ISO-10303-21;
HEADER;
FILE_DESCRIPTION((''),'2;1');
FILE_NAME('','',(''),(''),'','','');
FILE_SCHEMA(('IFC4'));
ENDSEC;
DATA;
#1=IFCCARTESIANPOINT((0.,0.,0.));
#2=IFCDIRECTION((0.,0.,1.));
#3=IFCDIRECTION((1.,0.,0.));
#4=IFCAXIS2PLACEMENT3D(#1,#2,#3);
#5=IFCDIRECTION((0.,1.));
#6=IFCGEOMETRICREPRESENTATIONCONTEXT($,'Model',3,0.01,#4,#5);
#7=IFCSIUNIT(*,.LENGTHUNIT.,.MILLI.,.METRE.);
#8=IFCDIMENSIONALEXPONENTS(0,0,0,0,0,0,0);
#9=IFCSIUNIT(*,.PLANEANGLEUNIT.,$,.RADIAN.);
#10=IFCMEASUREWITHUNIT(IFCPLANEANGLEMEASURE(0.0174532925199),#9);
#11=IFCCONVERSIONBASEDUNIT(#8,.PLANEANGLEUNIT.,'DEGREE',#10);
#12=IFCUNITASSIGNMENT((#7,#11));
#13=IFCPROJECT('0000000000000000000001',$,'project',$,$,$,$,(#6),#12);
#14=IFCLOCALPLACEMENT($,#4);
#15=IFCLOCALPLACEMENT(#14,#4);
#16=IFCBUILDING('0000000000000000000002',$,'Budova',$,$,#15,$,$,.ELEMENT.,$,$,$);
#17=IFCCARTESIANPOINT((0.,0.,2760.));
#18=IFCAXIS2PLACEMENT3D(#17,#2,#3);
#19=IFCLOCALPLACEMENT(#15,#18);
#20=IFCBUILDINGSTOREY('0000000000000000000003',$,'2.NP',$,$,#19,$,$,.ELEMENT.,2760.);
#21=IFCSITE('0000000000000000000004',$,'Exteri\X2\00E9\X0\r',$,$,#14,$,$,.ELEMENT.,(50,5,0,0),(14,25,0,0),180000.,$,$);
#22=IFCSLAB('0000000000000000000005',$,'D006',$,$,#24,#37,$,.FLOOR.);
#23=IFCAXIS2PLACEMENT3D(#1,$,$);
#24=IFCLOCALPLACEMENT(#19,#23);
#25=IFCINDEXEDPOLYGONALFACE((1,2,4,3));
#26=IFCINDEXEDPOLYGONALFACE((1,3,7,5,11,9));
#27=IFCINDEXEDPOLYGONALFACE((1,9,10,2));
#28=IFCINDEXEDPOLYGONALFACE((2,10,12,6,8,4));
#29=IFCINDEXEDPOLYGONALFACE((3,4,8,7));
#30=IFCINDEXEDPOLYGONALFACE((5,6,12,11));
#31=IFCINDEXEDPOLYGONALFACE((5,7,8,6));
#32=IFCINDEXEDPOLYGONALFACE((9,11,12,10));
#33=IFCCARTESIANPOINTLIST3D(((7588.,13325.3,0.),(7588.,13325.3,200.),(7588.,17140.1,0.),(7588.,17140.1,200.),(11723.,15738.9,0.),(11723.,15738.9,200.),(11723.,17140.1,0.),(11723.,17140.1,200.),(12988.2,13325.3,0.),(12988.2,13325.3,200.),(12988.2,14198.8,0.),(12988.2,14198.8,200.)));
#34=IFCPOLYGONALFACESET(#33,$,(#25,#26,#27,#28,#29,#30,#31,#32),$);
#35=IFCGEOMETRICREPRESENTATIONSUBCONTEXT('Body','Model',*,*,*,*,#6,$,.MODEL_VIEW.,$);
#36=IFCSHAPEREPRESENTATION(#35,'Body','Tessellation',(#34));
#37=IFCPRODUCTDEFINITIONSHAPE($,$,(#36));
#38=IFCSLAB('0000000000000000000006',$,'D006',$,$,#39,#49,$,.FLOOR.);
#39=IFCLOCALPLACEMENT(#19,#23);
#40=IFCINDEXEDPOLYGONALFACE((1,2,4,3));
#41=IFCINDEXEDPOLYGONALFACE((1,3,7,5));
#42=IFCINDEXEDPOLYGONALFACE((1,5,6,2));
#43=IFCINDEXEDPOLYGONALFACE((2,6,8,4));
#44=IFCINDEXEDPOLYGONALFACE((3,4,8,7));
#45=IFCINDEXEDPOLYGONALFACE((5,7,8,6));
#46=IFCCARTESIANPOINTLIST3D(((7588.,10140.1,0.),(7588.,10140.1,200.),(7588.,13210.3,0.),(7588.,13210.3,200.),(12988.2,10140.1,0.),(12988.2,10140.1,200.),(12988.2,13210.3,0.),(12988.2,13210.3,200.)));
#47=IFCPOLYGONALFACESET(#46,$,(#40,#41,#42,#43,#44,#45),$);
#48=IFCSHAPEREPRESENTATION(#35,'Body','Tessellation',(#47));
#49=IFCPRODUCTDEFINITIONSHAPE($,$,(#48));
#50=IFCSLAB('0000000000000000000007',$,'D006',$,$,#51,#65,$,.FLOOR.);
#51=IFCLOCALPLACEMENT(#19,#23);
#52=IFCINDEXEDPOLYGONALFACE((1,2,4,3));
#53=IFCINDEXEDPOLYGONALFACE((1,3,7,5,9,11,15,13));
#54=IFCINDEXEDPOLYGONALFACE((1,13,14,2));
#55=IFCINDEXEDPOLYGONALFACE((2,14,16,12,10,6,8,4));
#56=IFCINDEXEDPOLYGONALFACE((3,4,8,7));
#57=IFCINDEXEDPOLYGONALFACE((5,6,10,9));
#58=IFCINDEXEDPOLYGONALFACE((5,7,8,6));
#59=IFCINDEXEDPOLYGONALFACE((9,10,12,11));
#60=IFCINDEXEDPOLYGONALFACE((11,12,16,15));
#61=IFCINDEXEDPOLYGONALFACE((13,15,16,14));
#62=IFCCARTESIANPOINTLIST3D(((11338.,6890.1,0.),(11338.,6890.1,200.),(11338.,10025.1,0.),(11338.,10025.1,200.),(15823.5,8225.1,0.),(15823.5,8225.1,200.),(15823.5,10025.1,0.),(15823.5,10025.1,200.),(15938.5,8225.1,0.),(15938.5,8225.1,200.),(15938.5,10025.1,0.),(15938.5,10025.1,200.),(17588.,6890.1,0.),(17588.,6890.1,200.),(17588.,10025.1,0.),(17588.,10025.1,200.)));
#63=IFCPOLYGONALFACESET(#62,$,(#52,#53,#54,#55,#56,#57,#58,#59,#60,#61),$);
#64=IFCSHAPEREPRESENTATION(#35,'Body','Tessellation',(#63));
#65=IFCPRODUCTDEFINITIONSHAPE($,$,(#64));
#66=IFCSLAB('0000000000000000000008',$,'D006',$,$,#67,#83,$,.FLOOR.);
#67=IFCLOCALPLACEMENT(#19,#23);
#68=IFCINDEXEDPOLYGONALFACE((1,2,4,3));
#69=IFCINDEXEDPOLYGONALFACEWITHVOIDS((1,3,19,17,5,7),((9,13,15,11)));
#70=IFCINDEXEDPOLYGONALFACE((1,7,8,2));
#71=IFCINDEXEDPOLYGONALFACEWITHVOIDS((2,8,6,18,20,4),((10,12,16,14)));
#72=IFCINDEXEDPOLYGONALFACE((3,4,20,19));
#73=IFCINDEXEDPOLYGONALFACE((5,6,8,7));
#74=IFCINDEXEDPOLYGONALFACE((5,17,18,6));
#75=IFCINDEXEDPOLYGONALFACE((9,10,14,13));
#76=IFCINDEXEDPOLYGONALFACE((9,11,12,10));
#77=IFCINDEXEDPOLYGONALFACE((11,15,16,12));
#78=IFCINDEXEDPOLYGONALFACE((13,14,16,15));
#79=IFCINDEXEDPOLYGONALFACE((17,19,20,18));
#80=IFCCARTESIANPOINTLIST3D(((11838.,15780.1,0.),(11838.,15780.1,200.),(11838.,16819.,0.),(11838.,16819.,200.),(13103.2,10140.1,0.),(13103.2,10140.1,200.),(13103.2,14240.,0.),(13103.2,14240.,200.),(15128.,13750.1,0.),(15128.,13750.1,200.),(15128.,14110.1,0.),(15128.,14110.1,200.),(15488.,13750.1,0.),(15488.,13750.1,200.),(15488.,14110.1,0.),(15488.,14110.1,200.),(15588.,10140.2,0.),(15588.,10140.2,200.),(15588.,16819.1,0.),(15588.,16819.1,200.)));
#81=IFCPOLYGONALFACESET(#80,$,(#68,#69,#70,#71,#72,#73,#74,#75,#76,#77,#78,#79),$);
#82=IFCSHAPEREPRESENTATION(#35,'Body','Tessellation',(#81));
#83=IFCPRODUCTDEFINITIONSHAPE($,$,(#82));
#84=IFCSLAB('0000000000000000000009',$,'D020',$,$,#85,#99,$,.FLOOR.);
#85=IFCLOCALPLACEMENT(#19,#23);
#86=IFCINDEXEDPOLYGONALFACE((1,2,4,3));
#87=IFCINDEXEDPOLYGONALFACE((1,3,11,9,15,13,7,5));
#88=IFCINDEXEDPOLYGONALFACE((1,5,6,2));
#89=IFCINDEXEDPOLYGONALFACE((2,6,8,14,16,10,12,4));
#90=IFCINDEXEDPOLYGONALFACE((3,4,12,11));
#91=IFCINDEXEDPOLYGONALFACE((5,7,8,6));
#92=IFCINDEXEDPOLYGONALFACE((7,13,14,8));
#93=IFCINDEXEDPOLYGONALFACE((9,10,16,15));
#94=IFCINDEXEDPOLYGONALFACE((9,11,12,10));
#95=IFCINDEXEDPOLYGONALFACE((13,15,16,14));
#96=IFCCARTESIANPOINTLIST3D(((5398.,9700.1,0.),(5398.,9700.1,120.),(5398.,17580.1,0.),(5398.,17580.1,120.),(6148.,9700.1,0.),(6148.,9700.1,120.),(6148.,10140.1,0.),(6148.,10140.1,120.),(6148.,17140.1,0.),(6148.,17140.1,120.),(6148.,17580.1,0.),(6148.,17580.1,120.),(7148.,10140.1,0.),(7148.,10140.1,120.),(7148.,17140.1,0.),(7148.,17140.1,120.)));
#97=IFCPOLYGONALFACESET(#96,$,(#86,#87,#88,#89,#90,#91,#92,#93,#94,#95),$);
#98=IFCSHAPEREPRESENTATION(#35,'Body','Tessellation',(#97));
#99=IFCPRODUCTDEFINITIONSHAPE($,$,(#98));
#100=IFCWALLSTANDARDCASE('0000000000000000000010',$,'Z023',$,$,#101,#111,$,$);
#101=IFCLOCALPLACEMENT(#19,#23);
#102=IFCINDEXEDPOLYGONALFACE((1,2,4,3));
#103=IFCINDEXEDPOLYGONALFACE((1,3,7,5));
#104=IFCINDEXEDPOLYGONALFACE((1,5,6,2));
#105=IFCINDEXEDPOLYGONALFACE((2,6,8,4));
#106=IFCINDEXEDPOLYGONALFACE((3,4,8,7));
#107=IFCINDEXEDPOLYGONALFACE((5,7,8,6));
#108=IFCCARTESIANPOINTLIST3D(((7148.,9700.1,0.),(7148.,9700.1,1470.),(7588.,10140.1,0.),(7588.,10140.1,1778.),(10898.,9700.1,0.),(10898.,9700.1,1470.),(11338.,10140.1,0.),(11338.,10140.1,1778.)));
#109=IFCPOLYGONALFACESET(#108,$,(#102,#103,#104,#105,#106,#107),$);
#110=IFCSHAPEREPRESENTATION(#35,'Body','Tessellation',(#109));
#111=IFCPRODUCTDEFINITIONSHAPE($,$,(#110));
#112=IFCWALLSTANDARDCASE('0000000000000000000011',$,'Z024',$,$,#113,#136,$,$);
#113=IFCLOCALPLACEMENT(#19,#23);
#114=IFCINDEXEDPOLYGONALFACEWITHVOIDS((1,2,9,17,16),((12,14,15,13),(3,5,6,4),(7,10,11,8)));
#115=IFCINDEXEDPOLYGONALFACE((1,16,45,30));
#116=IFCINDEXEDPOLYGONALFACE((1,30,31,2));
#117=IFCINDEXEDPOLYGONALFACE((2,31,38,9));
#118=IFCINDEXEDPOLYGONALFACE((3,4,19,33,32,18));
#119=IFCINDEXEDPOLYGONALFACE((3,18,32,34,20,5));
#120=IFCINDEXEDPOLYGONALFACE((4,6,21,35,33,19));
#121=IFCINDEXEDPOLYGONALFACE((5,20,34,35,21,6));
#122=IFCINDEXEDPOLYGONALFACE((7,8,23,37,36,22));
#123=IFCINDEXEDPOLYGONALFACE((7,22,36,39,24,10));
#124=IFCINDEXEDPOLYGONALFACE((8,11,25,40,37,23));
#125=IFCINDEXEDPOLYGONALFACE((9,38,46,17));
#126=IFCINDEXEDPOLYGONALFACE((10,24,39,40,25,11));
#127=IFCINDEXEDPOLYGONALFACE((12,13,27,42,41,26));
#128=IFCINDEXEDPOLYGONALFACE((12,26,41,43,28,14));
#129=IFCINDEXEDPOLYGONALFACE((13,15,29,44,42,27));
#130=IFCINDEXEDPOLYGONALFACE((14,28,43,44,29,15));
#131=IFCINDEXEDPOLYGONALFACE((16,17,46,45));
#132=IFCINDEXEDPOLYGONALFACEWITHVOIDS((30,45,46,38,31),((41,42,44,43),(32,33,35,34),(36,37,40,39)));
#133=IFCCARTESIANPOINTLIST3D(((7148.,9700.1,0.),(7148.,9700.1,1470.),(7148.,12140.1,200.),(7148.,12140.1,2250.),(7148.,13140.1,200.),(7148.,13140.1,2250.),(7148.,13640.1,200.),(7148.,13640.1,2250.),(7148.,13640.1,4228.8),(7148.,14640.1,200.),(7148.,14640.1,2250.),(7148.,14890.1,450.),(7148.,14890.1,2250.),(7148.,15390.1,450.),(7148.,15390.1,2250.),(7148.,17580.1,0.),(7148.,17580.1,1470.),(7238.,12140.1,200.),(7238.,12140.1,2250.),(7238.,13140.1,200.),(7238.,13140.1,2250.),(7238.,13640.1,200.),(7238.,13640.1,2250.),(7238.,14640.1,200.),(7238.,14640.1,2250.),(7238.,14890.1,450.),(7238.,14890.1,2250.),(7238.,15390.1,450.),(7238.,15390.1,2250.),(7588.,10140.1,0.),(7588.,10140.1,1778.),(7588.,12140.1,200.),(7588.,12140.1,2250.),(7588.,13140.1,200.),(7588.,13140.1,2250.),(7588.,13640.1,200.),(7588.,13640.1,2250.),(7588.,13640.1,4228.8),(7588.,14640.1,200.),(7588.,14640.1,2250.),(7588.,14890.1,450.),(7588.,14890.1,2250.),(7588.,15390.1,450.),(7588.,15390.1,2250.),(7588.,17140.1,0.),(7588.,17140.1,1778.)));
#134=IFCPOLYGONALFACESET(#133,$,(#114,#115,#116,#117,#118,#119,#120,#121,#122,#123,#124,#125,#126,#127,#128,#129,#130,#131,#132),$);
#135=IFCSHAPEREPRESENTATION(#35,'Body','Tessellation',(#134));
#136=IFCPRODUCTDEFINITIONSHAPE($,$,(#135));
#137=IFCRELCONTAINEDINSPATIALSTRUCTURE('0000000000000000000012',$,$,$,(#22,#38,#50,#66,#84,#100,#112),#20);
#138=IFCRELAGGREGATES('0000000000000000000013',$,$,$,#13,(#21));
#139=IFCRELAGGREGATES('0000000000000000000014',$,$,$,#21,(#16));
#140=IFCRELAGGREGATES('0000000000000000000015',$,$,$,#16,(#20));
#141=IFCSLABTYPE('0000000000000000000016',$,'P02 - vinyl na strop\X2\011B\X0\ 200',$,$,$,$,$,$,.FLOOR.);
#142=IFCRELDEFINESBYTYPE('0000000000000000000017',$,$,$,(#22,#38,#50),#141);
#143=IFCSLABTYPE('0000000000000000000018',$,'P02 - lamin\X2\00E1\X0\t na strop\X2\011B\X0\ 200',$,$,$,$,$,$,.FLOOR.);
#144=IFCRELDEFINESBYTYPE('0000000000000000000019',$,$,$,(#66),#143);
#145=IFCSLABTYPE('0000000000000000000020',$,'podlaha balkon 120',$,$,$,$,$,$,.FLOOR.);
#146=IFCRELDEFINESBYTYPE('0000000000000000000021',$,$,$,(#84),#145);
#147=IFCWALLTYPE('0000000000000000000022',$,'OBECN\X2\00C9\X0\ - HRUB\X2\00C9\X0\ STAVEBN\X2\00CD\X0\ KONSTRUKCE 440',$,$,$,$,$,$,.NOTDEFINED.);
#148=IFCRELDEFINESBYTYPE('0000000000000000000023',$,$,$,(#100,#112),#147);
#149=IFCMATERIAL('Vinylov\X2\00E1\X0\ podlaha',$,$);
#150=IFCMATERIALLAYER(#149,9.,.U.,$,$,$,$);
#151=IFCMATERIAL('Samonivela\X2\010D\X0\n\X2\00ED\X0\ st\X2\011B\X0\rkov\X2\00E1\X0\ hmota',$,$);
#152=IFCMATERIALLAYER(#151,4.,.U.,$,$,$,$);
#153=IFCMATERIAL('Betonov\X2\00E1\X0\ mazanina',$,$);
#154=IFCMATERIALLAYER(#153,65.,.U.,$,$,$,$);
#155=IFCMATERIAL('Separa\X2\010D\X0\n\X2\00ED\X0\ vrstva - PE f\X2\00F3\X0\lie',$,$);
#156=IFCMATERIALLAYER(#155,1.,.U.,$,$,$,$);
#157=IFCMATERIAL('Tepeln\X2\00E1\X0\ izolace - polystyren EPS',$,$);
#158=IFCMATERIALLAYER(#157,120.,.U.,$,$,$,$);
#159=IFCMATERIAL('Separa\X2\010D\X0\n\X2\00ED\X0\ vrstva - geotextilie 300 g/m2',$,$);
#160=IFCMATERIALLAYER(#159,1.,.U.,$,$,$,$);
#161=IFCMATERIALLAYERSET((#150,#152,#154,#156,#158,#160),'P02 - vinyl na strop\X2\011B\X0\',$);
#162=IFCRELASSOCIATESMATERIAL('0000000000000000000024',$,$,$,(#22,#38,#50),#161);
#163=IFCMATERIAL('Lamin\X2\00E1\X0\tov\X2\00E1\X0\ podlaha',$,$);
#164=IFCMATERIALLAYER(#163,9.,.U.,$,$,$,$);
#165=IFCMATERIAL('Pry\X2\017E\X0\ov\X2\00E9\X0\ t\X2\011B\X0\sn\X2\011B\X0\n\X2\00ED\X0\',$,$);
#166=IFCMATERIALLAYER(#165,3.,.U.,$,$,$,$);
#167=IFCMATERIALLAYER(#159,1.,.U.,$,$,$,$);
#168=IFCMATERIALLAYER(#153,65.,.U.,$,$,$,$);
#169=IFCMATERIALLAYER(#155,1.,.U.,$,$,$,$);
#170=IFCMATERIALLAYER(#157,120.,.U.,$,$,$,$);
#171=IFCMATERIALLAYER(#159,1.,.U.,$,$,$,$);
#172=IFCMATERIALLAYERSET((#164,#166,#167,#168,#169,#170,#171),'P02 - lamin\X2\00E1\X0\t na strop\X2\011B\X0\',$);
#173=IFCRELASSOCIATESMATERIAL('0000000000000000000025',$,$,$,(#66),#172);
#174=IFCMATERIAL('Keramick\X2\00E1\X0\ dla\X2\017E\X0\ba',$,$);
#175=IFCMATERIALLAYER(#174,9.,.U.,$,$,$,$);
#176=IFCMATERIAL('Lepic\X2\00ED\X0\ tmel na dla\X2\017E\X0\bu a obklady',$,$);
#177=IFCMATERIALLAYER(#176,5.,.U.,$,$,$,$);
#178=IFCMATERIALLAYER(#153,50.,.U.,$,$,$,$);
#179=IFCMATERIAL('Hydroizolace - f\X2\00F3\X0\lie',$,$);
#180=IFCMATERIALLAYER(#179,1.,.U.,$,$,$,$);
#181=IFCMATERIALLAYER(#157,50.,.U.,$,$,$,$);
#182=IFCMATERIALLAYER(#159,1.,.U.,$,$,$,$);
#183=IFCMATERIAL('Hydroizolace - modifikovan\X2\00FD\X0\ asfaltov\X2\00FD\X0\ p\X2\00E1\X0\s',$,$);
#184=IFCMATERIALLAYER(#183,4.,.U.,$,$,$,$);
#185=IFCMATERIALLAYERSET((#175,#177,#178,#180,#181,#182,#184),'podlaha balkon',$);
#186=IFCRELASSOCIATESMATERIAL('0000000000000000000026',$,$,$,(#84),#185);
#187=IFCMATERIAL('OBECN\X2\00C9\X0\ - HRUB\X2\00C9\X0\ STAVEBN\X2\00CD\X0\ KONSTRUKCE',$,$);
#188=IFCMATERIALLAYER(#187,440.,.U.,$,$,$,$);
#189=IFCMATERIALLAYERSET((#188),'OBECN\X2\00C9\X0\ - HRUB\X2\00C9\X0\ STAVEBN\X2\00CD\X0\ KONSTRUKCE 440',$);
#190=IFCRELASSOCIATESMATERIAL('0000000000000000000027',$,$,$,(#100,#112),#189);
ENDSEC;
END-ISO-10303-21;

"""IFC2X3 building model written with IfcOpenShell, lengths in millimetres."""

from ifc_helpers import new_model, entity, si_unit, converted_unit, direction, frame, origin_with_axes, origin_2d_with_axis, place, context, subcontext, project, spatial, polyline, rectangle, outline, extrude, clip, halfspace, bounded_halfspace, material, layer, layer_set, layer_usage, type_object, element, save


model = new_model("IFC2X3")

# Units and contexts
model_context = context("Model", 3, precision=0.01, world=origin_with_axes(), true_north=direction((0.0, 1.0)))
body_context = subcontext(model_context, "Body", "Model", "MODEL_VIEW")
ifc_project = project(units=[si_unit("LENGTHUNIT", "METRE", prefix="MILLI"), converted_unit("PLANEANGLEUNIT", "DEGREE", entity("IfcPlaneAngleMeasure", 0.0174532925199), si_unit("PLANEANGLEUNIT", "RADIAN"), dimensions=[0, 0, 0, 0, 0, 0, 0])], contexts=[model_context])

# Site, building, storey
site_placement = place(None, origin_with_axes())
site = spatial("IfcSite", under=ifc_project, at=site_placement, Name="Exteriér", CompositionType="ELEMENT", RefLatitude=(50, 5, 0, 0), RefLongitude=(14, 25, 0, 0), RefElevation=180000.0)
building_placement = place(site_placement, origin_with_axes())
building = spatial("IfcBuilding", under=site, at=building_placement, Name="Budova", CompositionType="ELEMENT")
storey_placement = place(building_placement, frame((0.0, 0.0, 2760.0), z_axis=(0.0, 0.0, 1.0), x_axis=(1.0, 0.0, 0.0)))
storey = spatial("IfcBuildingStorey", under=building, at=storey_placement, Name="2.NP", CompositionType="ELEMENT", Elevation=2760.0)

# Slabs
ifc_material_1 = material(Name="Vinylová podlaha")
ifc_layer_1 = layer(ifc_material_1, 9.0, ventilated="UNKNOWN")
ifc_material_2 = material(Name="Samonivelační stěrková hmota")
ifc_layer_2 = layer(ifc_material_2, 4.0, ventilated="UNKNOWN")
ifc_material_3 = material(Name="Betonová mazanina")
ifc_layer_3 = layer(ifc_material_3, 65.0, ventilated="UNKNOWN")
ifc_material_4 = material(Name="Separační vrstva - PE fólie")
ifc_layer_4 = layer(ifc_material_4, 1.0, ventilated="UNKNOWN")
ifc_material_5 = material(Name="Tepelná izolace - polystyren EPS")
ifc_layer_5 = layer(ifc_material_5, 120.0, ventilated="UNKNOWN")
ifc_material_6 = material(Name="Separační vrstva - geotextilie 300 g/m2")
ifc_layer_6 = layer(ifc_material_6, 1.0, ventilated="UNKNOWN")
ifc_layer_set_1 = layer_set([ifc_layer_1, ifc_layer_2, ifc_layer_3, ifc_layer_4, ifc_layer_5, ifc_layer_6], Name="P02 - vinyl na stropě")
ifc_layer_usage_1 = layer_usage(ifc_layer_set_1, "AXIS3", "NEGATIVE", 200.0)
slab_type_1 = type_object("IfcSlabType", Name="P02 - vinyl na stropě 200", PredefinedType="FLOOR")
slab_1_placement = place(storey_placement, frame((11723.0, 17140.1, 0.0), z_axis=(0.0, 0.0, 1.0), x_axis=(1.0, 0.0, 0.0)))
element("IfcSlab", 1, at=slab_1_placement, inside=storey, type_object=slab_type_1, material=ifc_layer_usage_1, Name="D006", PredefinedType="FLOOR", context=body_context, shape_type="SweptSolid", body=[
    extrude(outline(polyline([(0.0, 0.0), (-4135.0, 0.0), (-4135.0, -3814.9), (1265.2, -3814.9), (1265.2, -2941.3), (0.0, -1401.2), (0.0, 0.0)])), origin_with_axes(), (0.0, 0.0, 1.0), 200.0),
])
ifc_layer_usage_2 = layer_usage(ifc_layer_set_1, "AXIS3", "NEGATIVE", 200.0)
slab_2_placement = place(storey_placement, frame((7588.0, 13210.3, 0.0), z_axis=(0.0, 0.0, 1.0), x_axis=(1.0, 0.0, 0.0)))
element("IfcSlab", 2, at=slab_2_placement, inside=storey, type_object=slab_type_1, material=ifc_layer_usage_2, Name="D006", PredefinedType="FLOOR", context=body_context, shape_type="SweptSolid", body=[
    extrude(outline(polyline([(0.0, 0.0), (0.0, -3070.1), (5400.2, -3070.1), (5400.2, 0.0), (0.0, 0.0)])), origin_with_axes(), (0.0, 0.0, 1.0), 200.0),
])
ifc_layer_usage_3 = layer_usage(ifc_layer_set_1, "AXIS3", "NEGATIVE", 200.0)
slab_3_placement = place(storey_placement, frame((11338.0, 10025.1, 0.0), z_axis=(0.0, 0.0, 1.0), x_axis=(1.0, 0.0, 0.0)))
element("IfcSlab", 3, at=slab_3_placement, inside=storey, type_object=slab_type_1, material=ifc_layer_usage_3, Name="D006", PredefinedType="FLOOR", context=body_context, shape_type="SweptSolid", body=[
    extrude(outline(polyline([(0.0, 0.0), (0.0, -3135.0), (6250.0, -3135.0), (6250.0, 0.0), (4600.5, 0.0), (4600.5, -1800.0), (4485.5, -1800.0), (4485.5, 0.0), (0.0, 0.0)])), origin_with_axes(), (0.0, 0.0, 1.0), 200.0),
])

# Shared definitions
ifc_material_7 = material(Name="Hydroizolace - modifikovaný asfaltový pás")

# Slabs
ifc_material_8 = material(Name="Laminátová podlaha")
ifc_layer_7 = layer(ifc_material_8, 9.0, ventilated="UNKNOWN")
ifc_material_9 = material(Name="Pryžové těsnění")
ifc_layer_8 = layer(ifc_material_9, 3.0, ventilated="UNKNOWN")
ifc_layer_9 = layer(ifc_material_6, 1.0, ventilated="UNKNOWN")
ifc_layer_10 = layer(ifc_material_3, 65.0, ventilated="UNKNOWN")
ifc_layer_11 = layer(ifc_material_4, 1.0, ventilated="UNKNOWN")
ifc_layer_12 = layer(ifc_material_5, 120.0, ventilated="UNKNOWN")
ifc_layer_13 = layer(ifc_material_6, 1.0, ventilated="UNKNOWN")
ifc_layer_set_2 = layer_set([ifc_layer_7, ifc_layer_8, ifc_layer_9, ifc_layer_10, ifc_layer_11, ifc_layer_12, ifc_layer_13], Name="P02 - laminát na stropě")
ifc_layer_usage_4 = layer_usage(ifc_layer_set_2, "AXIS3", "NEGATIVE", 200.0)
slab_type_2 = type_object("IfcSlabType", Name="P02 - laminát na stropě 200", PredefinedType="FLOOR")
slab_4_placement = place(storey_placement, frame((11838.0, 16819.0, 0.0), z_axis=(0.0, 0.0, 1.0), x_axis=(1.0, 0.0, 0.0)))
element("IfcSlab", 4, at=slab_4_placement, inside=storey, type_object=slab_type_2, material=ifc_layer_usage_4, Name="D006", PredefinedType="FLOOR", context=body_context, shape_type="SweptSolid", body=[
    extrude(outline(polyline([(0.0, 0.0), (0.0, -1038.9), (1265.2, -2579.0), (1265.2, -6678.9), (3750.0, -6678.9), (3750.0, 0.1), (0.0, 0.0)]), holes=[polyline([(3650.0, -2708.9), (3650.0, -3068.9), (3290.0, -3068.9), (3290.0, -2708.9), (3650.0, -2708.9)])]), origin_with_axes(), (0.0, 0.0, 1.0), 200.0),
])
ifc_material_10 = material(Name="Keramická dlažba")
ifc_layer_14 = layer(ifc_material_10, 9.0, ventilated="UNKNOWN")
ifc_material_11 = material(Name="Lepicí tmel na dlažbu a obklady")
ifc_layer_15 = layer(ifc_material_11, 5.0, ventilated="UNKNOWN")
ifc_layer_16 = layer(ifc_material_3, 50.0, ventilated="UNKNOWN")
ifc_material_12 = material(Name="Hydroizolace - fólie")
ifc_layer_17 = layer(ifc_material_12, 1.0, ventilated="UNKNOWN")
ifc_layer_18 = layer(ifc_material_5, 50.0, ventilated="UNKNOWN")
ifc_layer_19 = layer(ifc_material_6, 1.0, ventilated="UNKNOWN")
ifc_layer_20 = layer(ifc_material_7, 4.0, ventilated="UNKNOWN")
ifc_layer_set_3 = layer_set([ifc_layer_14, ifc_layer_15, ifc_layer_16, ifc_layer_17, ifc_layer_18, ifc_layer_19, ifc_layer_20], Name="podlaha balkon")
ifc_layer_usage_5 = layer_usage(ifc_layer_set_3, "AXIS3", "NEGATIVE", 120.0)
slab_type_3 = type_object("IfcSlabType", Name="podlaha balkon 120", PredefinedType="FLOOR")
slab_5_placement = place(storey_placement, frame((5398.0, 17580.1, 0.0), z_axis=(0.0, 0.0, 1.0), x_axis=(1.0, 0.0, 0.0)))
element("IfcSlab", 5, at=slab_5_placement, inside=storey, type_object=slab_type_3, material=ifc_layer_usage_5, Name="D020", PredefinedType="FLOOR", context=body_context, shape_type="SweptSolid", body=[
    extrude(outline(polyline([(0.0, 0.0), (0.0, -7880.0), (750.0, -7880.0), (750.0, -7440.0), (1750.0, -7440.0), (1750.0, -440.0), (750.0, -440.0), (750.0, 0.0), (0.0, 0.0)])), origin_with_axes(), (0.0, 0.0, 1.0), 120.0),
])

# Wall
ifc_material_13 = material(Name="OBECNÉ - HRUBÉ STAVEBNÍ KONSTRUKCE")
ifc_layer_21 = layer(ifc_material_13, 440.0, ventilated="UNKNOWN")
ifc_layer_set_4 = layer_set([ifc_layer_21], Name="OBECNÉ - HRUBÉ STAVEBNÍ KONSTRUKCE 440")
ifc_layer_usage_6 = layer_usage(ifc_layer_set_4, "AXIS2", "POSITIVE", -440.0)
wall_type_1 = type_object("IfcWallType", Name="OBECNÉ - HRUBÉ STAVEBNÍ KONSTRUKCE 440", PredefinedType="NOTDEFINED")
wall_1_placement = place(storey_placement, frame((10898.0, 9700.1, 0.0), z_axis=(0.0, 0.0, 1.0), x_axis=(-1.0, 0.0, 0.0)))
element("IfcWallStandardCase", 6, at=wall_1_placement, inside=storey, type_object=wall_type_1, material=ifc_layer_usage_6, Name="Z023", context=body_context, shape_type="Clipping", body=[
    clip(extrude(outline(polyline([(-440.0, -440.0), (3310.0, -440.0), (3750.0, 0.0), (0.0, 0.0), (-440.0, -440.0)])), origin_with_axes(), (0.0, 0.0, 1.0), 2000.0), halfspace(frame((0.0, 690.7, 986.4), z_axis=(0.0, -0.573576, -0.819152), x_axis=(0.0, 0.819152, -0.573576)), True)),
])

# Wall, openings
ifc_layer_usage_7 = layer_usage(ifc_layer_set_4, "AXIS2", "POSITIVE", -440.0)
wall_2_placement = place(storey_placement, frame((7148.0, 9700.1, 0.0), z_axis=(0.0, 0.0, 1.0), x_axis=(0.0, 1.0, 0.0)))
wall_2 = element("IfcWallStandardCase", 7, at=wall_2_placement, inside=storey, type_object=wall_type_1, material=ifc_layer_usage_7, Name="Z024", context=body_context, shape_type="Clipping", body=[
    clip(clip(extrude(outline(polyline([(440.0, -440.0), (7440.0, -440.0), (7880.0, 0.0), (0.0, 0.0), (440.0, -440.0)])), origin_with_axes(), (0.0, 0.0, 1.0), 6000.0), bounded_halfspace(frame((3283.1, 0.0, 4688.7), z_axis=(-0.573576, 0.0, -0.819152), x_axis=(0.0, 1.0, 0.0)), True, origin_with_axes(), polyline([(3940.0, -450.0), (8280.0, -450.0), (8280.0, 10.0), (3940.0, 10.0), (3940.0, -450.0)]))), bounded_halfspace(frame((-690.7, 0.0, 986.4), z_axis=(0.573576, 0.0, -0.819152), x_axis=(0.0, 1.0, 0.0)), True, origin_with_axes(), polyline([(-436.0, -450.0), (3940.0, -450.0), (3940.0, 10.0), (-436.0, 10.0), (-436.0, -450.0)]))),
])
opening_1_placement = place(wall_2_placement, frame((4440.0, 0.0, 200.0), z_axis=(0.0, 0.0, 1.0), x_axis=(1.0, 0.0, 0.0)))
element("IfcOpeningElement", 8, at=opening_1_placement, cuts=wall_2, context=body_context, shape_type="SweptSolid", body=[
    extrude(rectangle(XDim=1000.0, YDim=2050.0, at=origin_2d_with_axis()), frame((0.0, -90.0, 1025.0), z_axis=(0.0, 1.0, 0.0), x_axis=(-1.0, 0.0, 0.0)), (0.0, 0.0, -1.0), 790.0),
    extrude(rectangle(XDim=1000.0, YDim=2050.0, at=origin_2d_with_axis()), frame((0.0, -90.0, 1025.0), z_axis=(0.0, -1.0, 0.0), x_axis=(-1.0, 0.0, 0.0)), (0.0, 0.0, -1.0), 530.0),
])
opening_2_placement = place(wall_2_placement, frame((2940.0, 0.0, 200.0), z_axis=(0.0, 0.0, 1.0), x_axis=(1.0, 0.0, 0.0)))
element("IfcOpeningElement", 9, at=opening_2_placement, cuts=wall_2, context=body_context, shape_type="SweptSolid", body=[
    extrude(rectangle(XDim=1000.0, YDim=2050.0, at=origin_2d_with_axis()), frame((0.0, -90.0, 1025.0), z_axis=(0.0, -1.0, 0.0), x_axis=(1.0, 0.0, 0.0)), (0.0, 0.0, 1.0), 790.0),
    extrude(rectangle(XDim=1000.0, YDim=2050.0, at=origin_2d_with_axis()), frame((0.0, -90.0, 1025.0), z_axis=(0.0, 1.0, 0.0), x_axis=(1.0, 0.0, 0.0)), (0.0, 0.0, 1.0), 530.0),
])
opening_3_placement = place(wall_2_placement, frame((5440.0, 0.0, 450.0), z_axis=(0.0, 0.0, 1.0), x_axis=(1.0, 0.0, 0.0)))
element("IfcOpeningElement", 10, at=opening_3_placement, cuts=wall_2, context=body_context, shape_type="SweptSolid", body=[
    extrude(rectangle(XDim=500.0, YDim=1800.0, at=origin_2d_with_axis()), frame((0.0, -90.0, 900.0), z_axis=(0.0, 1.0, 0.0), x_axis=(-1.0, 0.0, 0.0)), (0.0, 0.0, -1.0), 790.0),
    extrude(rectangle(XDim=500.0, YDim=1800.0, at=origin_2d_with_axis()), frame((0.0, -90.0, 900.0), z_axis=(0.0, -1.0, 0.0), x_axis=(-1.0, 0.0, 0.0)), (0.0, 0.0, -1.0), 530.0),
])

save(model, "model.ifc")
